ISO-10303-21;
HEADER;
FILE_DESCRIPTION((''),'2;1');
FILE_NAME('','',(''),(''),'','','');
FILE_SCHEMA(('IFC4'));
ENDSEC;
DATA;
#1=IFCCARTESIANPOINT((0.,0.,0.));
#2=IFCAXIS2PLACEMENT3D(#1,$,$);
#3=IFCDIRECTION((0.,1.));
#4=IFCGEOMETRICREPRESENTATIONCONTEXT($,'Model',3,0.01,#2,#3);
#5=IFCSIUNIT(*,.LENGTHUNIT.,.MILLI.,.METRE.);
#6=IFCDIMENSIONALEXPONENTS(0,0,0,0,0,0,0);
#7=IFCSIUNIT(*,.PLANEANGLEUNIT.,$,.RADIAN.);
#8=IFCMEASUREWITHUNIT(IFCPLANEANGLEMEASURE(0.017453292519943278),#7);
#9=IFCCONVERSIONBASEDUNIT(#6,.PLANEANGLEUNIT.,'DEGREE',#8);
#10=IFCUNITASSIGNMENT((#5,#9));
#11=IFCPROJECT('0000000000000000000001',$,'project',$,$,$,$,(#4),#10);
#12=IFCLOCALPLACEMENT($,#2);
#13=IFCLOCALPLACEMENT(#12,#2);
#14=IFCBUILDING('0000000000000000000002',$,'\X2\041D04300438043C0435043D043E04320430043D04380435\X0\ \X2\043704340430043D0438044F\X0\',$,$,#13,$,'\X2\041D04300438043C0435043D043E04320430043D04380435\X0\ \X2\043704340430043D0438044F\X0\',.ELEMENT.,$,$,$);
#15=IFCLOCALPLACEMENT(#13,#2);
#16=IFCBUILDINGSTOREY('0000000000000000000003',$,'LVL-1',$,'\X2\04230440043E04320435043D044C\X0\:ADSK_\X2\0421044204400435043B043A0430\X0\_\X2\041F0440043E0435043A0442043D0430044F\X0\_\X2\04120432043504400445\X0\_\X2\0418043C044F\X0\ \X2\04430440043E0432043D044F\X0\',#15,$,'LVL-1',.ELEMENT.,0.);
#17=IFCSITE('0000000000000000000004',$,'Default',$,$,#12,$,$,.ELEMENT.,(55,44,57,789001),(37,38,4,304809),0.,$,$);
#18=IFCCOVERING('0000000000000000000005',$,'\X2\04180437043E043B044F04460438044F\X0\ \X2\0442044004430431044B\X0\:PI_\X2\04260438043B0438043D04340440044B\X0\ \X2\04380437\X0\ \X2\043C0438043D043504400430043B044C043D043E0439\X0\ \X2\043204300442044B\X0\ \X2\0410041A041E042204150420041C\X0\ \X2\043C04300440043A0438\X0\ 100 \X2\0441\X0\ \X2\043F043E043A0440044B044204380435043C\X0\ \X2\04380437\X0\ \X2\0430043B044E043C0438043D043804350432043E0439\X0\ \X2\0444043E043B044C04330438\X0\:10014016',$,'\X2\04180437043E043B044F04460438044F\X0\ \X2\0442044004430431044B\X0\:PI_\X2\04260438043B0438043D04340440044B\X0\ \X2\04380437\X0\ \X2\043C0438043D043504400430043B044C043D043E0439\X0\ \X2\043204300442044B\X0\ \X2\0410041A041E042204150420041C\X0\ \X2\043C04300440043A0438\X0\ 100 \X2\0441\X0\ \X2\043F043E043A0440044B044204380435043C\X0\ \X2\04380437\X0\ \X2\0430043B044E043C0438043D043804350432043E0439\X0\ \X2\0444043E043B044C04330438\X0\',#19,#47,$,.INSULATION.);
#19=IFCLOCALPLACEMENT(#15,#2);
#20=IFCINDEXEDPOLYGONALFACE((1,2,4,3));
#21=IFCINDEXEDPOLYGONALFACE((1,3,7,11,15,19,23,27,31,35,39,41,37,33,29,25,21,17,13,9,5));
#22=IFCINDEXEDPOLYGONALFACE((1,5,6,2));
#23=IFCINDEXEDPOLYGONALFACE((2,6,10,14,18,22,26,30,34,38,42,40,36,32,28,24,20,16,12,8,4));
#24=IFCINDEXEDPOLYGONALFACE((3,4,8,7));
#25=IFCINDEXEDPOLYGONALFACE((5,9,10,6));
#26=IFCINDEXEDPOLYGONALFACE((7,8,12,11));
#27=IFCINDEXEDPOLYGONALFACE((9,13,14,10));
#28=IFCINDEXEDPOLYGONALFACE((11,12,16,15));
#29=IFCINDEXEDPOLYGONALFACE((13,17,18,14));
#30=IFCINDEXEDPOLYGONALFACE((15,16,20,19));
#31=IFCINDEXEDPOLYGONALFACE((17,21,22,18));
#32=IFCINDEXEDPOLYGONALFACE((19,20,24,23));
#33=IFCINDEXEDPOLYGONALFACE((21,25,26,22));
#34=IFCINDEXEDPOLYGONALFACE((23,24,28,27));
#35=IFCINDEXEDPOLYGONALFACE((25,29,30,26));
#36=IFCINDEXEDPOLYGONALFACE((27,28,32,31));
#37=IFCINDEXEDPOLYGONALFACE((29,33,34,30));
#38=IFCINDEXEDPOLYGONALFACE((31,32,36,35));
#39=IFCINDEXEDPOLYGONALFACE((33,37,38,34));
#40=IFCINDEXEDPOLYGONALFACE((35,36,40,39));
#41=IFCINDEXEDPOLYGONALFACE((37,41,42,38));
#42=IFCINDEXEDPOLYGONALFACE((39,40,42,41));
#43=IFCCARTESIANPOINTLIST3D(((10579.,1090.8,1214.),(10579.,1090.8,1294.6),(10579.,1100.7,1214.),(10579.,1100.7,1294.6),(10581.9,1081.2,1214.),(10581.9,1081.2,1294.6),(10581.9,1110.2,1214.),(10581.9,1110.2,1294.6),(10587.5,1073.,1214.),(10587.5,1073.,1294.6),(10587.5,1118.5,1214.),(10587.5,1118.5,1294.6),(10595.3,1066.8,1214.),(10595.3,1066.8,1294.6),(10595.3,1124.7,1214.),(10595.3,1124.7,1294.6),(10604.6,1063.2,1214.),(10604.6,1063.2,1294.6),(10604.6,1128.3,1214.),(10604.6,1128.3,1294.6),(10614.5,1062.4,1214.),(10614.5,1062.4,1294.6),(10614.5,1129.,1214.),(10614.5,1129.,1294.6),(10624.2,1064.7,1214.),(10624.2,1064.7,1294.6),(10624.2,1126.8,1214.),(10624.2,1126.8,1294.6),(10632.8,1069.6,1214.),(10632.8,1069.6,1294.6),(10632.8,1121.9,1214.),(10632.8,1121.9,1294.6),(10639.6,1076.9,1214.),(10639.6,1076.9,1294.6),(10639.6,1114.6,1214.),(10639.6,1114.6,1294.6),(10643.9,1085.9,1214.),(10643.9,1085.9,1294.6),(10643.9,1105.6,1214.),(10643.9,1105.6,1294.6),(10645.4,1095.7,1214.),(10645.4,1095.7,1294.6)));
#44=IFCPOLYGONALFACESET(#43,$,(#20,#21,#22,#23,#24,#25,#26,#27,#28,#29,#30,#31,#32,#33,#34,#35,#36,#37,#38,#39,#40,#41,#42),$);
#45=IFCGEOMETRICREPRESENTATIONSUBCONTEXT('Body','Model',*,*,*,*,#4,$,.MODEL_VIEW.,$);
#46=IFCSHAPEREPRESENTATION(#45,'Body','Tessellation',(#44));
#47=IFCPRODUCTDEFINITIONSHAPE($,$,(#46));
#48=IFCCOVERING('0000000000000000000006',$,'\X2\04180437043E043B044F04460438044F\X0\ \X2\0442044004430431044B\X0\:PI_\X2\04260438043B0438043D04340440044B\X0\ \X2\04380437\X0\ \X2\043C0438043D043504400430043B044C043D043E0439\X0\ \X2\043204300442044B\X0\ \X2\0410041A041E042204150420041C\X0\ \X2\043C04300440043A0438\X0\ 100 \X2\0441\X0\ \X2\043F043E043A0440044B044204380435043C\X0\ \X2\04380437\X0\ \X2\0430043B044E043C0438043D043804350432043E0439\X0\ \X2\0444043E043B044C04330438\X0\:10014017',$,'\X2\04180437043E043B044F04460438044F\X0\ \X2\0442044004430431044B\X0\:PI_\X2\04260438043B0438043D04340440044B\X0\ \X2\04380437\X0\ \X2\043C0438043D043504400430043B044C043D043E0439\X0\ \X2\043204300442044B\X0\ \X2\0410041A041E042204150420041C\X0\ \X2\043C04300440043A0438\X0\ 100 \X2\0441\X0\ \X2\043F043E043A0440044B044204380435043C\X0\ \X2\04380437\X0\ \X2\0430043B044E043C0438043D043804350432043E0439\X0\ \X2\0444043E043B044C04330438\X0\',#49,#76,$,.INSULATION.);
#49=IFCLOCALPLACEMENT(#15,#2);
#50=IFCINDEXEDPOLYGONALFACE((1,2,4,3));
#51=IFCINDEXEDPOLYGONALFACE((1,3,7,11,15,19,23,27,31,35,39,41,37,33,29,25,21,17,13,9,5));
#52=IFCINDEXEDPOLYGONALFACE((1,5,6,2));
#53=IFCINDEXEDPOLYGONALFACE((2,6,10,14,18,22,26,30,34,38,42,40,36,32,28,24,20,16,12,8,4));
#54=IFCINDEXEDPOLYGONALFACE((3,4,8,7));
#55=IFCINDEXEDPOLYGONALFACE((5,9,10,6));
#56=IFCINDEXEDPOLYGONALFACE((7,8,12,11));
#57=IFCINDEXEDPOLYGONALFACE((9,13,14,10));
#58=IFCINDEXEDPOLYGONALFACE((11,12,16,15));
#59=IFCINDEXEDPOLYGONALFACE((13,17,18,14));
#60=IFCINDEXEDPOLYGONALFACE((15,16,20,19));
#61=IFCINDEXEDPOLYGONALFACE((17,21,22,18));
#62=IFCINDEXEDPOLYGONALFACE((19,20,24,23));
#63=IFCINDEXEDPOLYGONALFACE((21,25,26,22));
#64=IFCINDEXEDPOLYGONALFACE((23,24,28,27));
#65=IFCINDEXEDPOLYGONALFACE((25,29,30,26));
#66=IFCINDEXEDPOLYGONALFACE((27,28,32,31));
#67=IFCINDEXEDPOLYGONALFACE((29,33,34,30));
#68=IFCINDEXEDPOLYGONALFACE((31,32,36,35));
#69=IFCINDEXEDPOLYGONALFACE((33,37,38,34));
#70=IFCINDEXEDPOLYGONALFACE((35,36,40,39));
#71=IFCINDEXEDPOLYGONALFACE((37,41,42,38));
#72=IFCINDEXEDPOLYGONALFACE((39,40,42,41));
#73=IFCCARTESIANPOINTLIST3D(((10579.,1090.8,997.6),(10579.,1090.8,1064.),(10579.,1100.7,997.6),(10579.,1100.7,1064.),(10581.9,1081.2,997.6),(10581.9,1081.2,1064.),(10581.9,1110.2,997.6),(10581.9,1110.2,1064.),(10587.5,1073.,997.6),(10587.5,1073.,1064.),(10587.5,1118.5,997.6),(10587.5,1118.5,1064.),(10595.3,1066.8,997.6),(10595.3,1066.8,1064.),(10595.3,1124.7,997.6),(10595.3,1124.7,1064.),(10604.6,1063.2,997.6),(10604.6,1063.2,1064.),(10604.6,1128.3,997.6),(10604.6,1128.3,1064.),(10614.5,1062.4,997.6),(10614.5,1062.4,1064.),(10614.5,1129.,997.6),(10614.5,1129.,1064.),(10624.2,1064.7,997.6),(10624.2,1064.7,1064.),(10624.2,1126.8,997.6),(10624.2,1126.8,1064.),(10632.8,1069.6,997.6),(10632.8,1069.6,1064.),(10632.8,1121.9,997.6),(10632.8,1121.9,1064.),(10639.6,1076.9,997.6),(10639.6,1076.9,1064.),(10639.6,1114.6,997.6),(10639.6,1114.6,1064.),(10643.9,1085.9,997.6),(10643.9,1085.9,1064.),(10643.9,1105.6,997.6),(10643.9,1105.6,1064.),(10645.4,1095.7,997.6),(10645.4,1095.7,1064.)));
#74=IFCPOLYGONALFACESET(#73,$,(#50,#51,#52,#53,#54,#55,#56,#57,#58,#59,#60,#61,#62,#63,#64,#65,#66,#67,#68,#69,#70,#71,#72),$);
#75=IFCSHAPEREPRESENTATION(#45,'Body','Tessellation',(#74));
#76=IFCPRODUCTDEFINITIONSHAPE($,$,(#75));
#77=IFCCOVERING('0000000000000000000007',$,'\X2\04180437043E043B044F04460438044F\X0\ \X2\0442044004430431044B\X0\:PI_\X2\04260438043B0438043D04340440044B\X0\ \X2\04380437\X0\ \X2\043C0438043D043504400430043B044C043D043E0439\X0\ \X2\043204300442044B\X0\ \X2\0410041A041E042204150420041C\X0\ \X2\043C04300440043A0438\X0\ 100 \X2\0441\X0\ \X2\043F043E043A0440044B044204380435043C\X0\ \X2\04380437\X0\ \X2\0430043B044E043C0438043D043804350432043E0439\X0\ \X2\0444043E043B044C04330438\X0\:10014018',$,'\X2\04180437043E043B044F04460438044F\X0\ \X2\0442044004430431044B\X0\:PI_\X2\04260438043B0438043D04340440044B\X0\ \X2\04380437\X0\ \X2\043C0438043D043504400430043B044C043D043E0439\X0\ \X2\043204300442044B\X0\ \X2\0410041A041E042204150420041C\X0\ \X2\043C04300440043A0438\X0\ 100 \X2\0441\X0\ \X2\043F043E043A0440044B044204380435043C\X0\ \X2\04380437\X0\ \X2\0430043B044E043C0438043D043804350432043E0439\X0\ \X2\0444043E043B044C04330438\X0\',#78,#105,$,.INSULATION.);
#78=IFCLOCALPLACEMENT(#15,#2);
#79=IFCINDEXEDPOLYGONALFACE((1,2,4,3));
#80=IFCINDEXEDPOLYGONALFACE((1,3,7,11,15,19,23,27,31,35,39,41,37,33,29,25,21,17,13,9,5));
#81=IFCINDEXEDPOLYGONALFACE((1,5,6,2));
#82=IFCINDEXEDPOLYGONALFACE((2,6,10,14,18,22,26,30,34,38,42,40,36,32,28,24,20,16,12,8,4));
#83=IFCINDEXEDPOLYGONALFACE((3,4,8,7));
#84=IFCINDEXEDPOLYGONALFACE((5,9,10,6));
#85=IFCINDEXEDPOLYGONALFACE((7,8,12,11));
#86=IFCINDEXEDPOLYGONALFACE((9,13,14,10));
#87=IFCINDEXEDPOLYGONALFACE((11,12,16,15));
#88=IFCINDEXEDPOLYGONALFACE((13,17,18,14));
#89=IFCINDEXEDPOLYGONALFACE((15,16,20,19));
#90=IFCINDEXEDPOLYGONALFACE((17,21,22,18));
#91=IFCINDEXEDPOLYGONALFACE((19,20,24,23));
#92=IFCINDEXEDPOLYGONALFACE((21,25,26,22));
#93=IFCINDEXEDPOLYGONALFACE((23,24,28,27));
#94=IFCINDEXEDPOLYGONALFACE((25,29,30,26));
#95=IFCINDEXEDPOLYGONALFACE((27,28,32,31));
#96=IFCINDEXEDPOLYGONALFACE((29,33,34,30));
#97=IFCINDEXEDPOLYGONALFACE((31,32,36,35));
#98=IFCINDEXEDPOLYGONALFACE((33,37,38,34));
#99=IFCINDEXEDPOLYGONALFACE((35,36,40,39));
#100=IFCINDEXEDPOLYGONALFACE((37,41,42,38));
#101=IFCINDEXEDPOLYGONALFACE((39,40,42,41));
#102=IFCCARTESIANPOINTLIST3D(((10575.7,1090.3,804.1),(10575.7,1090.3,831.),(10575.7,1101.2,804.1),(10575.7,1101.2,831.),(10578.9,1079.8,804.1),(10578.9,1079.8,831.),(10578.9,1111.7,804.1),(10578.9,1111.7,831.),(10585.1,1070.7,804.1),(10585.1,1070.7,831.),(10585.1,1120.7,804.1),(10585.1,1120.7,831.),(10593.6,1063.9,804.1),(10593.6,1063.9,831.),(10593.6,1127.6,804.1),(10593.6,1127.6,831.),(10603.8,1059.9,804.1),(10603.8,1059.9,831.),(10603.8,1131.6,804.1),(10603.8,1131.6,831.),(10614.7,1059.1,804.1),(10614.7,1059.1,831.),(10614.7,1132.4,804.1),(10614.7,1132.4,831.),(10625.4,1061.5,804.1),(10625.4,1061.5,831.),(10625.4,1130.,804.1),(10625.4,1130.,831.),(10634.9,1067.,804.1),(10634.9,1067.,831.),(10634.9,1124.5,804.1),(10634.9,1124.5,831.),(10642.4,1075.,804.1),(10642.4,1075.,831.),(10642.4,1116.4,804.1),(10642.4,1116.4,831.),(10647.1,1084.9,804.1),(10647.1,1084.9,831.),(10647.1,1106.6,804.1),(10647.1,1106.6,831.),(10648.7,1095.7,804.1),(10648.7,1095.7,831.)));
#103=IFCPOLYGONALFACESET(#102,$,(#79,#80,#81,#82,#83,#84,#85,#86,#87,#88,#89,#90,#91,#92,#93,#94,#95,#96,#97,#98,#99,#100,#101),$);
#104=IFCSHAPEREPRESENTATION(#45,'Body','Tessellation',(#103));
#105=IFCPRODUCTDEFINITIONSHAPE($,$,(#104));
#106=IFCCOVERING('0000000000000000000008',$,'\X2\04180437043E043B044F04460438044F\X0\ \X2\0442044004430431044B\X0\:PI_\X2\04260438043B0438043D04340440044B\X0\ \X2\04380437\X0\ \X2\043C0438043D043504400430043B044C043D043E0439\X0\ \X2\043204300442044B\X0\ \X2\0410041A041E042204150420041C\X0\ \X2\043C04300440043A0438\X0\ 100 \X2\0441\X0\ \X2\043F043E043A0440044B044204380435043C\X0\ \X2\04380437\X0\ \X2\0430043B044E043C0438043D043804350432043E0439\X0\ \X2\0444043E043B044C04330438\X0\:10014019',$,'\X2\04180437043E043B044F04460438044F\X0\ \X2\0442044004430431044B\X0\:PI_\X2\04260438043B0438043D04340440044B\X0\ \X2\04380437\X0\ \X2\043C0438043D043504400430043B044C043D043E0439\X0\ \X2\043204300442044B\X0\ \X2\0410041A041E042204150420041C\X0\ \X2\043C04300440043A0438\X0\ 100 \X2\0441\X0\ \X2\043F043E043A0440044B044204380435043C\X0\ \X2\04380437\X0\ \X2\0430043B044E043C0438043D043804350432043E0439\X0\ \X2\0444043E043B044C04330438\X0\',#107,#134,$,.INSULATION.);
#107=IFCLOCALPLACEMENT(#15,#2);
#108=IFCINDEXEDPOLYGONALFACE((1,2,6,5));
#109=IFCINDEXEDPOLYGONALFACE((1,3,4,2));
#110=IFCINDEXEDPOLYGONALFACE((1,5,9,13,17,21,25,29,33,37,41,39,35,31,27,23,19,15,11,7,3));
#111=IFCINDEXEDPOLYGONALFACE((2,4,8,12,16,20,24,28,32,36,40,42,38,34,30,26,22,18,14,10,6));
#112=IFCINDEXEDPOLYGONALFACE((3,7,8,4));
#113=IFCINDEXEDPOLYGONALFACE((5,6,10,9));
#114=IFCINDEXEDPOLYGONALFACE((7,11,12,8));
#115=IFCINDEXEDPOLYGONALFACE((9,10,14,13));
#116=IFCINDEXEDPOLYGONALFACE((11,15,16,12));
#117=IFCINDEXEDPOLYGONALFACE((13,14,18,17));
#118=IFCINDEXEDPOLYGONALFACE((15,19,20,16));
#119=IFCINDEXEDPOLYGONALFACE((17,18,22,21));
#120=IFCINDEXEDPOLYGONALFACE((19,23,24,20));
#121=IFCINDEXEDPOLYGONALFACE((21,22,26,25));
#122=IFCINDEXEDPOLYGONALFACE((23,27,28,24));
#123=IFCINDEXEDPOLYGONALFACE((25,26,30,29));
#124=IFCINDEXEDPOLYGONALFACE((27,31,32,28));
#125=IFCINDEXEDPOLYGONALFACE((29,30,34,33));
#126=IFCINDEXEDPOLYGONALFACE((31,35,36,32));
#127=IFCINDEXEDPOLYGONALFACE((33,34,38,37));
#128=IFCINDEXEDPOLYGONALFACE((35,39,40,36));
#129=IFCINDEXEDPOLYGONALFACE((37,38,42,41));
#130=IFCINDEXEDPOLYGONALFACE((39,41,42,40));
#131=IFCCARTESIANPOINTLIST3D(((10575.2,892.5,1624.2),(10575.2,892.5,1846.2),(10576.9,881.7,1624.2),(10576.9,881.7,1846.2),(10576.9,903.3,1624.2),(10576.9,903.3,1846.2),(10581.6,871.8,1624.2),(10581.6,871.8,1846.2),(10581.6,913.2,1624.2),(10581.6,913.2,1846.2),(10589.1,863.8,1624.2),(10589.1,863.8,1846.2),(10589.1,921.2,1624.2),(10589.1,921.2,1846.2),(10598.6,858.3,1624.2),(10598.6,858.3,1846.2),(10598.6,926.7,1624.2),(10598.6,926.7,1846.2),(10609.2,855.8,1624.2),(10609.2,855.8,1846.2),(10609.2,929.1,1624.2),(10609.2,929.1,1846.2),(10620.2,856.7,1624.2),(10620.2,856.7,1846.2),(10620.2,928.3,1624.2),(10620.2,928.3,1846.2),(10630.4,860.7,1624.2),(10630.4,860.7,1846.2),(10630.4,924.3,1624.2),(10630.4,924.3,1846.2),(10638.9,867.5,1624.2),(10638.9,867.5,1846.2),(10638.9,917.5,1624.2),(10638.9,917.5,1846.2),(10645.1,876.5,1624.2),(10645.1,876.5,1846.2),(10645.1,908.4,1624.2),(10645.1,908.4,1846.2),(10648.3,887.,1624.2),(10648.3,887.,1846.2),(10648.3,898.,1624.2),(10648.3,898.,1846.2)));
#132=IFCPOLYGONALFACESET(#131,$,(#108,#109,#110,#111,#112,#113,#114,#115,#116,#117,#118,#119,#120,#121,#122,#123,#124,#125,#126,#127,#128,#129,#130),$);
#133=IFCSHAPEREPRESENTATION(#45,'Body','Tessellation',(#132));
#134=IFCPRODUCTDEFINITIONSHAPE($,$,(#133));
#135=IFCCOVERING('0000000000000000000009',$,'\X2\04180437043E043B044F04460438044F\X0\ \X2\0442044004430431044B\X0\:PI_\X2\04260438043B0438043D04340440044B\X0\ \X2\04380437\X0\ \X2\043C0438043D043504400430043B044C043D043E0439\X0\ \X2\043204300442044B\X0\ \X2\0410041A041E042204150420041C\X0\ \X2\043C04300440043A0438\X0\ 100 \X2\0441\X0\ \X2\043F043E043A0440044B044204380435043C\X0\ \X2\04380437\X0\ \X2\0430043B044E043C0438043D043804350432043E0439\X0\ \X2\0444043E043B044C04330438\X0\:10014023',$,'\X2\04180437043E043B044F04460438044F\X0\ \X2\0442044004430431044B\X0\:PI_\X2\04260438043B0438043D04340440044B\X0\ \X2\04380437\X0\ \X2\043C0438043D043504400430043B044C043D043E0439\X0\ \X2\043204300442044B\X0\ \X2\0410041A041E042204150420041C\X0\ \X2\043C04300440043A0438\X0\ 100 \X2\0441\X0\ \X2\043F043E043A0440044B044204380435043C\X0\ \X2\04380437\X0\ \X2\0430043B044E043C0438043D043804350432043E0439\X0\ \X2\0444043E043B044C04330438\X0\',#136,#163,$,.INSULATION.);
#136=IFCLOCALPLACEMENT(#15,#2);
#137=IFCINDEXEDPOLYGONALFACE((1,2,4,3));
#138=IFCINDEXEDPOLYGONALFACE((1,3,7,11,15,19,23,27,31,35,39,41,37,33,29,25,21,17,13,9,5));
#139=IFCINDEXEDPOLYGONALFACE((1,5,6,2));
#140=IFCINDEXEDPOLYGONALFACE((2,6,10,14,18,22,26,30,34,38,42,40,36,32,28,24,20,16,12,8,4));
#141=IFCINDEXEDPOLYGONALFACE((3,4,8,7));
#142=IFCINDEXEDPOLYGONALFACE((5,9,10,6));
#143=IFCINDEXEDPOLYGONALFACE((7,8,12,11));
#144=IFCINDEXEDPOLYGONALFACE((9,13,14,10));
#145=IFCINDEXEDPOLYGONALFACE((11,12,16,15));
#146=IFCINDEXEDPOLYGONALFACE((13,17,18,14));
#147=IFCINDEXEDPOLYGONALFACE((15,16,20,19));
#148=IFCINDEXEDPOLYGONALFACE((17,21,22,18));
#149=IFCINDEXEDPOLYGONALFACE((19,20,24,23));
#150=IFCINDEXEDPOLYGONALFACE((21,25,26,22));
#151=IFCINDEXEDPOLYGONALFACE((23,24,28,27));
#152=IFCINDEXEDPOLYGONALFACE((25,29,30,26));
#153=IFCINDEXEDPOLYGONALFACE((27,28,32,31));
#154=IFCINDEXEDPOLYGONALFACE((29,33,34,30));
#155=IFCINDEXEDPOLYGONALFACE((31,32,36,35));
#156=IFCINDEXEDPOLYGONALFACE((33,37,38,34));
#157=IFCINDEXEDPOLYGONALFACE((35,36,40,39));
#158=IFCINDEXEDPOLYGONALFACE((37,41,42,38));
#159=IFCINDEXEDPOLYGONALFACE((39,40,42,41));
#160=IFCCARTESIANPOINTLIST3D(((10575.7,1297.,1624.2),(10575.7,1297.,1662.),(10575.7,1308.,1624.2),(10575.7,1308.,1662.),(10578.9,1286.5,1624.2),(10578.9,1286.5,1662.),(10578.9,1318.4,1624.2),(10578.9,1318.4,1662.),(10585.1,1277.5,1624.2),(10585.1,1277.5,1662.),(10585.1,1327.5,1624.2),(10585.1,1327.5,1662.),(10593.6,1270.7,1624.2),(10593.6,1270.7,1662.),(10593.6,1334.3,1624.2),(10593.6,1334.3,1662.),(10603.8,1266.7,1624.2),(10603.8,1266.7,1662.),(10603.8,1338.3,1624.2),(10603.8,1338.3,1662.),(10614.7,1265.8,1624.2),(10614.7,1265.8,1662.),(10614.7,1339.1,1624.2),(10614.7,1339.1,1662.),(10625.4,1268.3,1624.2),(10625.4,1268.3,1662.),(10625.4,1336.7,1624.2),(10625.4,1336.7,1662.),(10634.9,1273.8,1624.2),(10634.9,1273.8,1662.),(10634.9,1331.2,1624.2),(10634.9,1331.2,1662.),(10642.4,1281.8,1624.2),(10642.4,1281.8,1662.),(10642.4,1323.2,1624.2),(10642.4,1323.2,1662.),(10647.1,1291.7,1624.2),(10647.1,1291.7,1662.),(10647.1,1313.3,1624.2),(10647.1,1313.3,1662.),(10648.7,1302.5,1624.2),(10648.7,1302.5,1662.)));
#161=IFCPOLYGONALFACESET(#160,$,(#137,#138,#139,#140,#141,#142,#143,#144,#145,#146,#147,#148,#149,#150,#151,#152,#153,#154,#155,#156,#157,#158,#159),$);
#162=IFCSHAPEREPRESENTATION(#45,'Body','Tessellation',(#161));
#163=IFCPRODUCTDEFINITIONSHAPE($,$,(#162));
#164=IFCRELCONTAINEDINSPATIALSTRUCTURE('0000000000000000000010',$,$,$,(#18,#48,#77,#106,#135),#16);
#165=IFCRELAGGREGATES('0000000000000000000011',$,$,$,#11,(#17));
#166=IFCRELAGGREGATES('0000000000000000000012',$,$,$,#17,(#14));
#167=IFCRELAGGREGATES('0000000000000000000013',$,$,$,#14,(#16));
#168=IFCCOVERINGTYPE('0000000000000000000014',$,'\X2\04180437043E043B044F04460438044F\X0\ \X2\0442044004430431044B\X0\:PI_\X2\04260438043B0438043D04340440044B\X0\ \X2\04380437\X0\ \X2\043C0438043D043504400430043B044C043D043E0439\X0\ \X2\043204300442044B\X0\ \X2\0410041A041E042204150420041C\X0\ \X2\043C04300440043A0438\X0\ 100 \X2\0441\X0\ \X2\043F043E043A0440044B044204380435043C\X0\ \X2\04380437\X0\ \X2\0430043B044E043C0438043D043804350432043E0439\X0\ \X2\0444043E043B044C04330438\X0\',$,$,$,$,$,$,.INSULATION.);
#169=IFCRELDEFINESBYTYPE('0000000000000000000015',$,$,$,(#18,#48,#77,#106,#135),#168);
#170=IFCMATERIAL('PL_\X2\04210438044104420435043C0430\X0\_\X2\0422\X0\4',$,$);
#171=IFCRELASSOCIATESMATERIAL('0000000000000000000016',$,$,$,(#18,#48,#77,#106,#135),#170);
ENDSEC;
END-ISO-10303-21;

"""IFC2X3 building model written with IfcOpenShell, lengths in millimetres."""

from ifc_helpers import new_model, entity, si_unit, converted_unit, direction, frame, origin, origin_2d_with_axis, place, context, subcontext, project, spatial, circle, extrude, material, type_object, element, save


model = new_model("IFC2X3")

# Units and contexts
model_context = context("Model", 3, precision=0.01, world=origin(), true_north=direction((0.0, 1.0)))
body_context = subcontext(model_context, "Body", "Model", "MODEL_VIEW")
ifc_project = project(units=[si_unit("LENGTHUNIT", "METRE", prefix="MILLI"), converted_unit("PLANEANGLEUNIT", "DEGREE", entity("IfcPlaneAngleMeasure", 0.017453292519943278), si_unit("PLANEANGLEUNIT", "RADIAN"), dimensions=[0, 0, 0, 0, 0, 0, 0])], contexts=[model_context])

# Site, building, storey
site_placement = place(None, origin())
site = spatial("IfcSite", under=ifc_project, at=site_placement, Name="Default", CompositionType="ELEMENT", RefLatitude=(55, 44, 57, 789001), RefLongitude=(37, 38, 4, 304809), RefElevation=0.0)
building_placement = place(site_placement, origin())
building = spatial("IfcBuilding", under=site, at=building_placement, Name="Наименование здания", LongName="Наименование здания", CompositionType="ELEMENT")
storey_placement = place(building_placement, origin())
storey = spatial("IfcBuildingStorey", under=building, at=storey_placement, Name="LVL-1", ObjectType="Уровень:ADSK_Стрелка_Проектная_Вверх_Имя уровня", LongName="LVL-1", CompositionType="ELEMENT", Elevation=0.0)

# Coverings
covering_type = type_object("IfcCoveringType", Name="Изоляция трубы:PI_Цилиндры из минеральной ваты АКОТЕРМ марки 100 с покрытием из алюминиевой фольги", PredefinedType="INSULATION")
ifc_material_1 = material(Name="PL_Система_Т4")
covering_1_placement = place(storey_placement, origin())
element("IfcCovering", 1, at=covering_1_placement, inside=storey, type_object=covering_type, material=ifc_material_1, Name="Изоляция трубы:PI_Цилиндры из минеральной ваты АКОТЕРМ марки 100 с покрытием из алюминиевой фольги:10014016", ObjectType="Изоляция трубы:PI_Цилиндры из минеральной ваты АКОТЕРМ марки 100 с покрытием из алюминиевой фольги", PredefinedType="INSULATION", context=body_context, shape_type="SweptSolid", body=[
    extrude(circle(Radius=33.4, at=origin_2d_with_axis()), frame((10612.0, 1095.7, 1214.0)), (0.0, 0.0, 1.0), 80.6),
])
covering_2_placement = place(storey_placement, origin())
element("IfcCovering", 2, at=covering_2_placement, inside=storey, type_object=covering_type, material=ifc_material_1, Name="Изоляция трубы:PI_Цилиндры из минеральной ваты АКОТЕРМ марки 100 с покрытием из алюминиевой фольги:10014017", ObjectType="Изоляция трубы:PI_Цилиндры из минеральной ваты АКОТЕРМ марки 100 с покрытием из алюминиевой фольги", PredefinedType="INSULATION", context=body_context, shape_type="SweptSolid", body=[
    extrude(circle(Radius=33.4, at=origin_2d_with_axis()), frame((10612.0, 1095.7, 997.6)), (0.0, 0.0, 1.0), 66.4),
])
covering_3_placement = place(storey_placement, origin())
element("IfcCovering", 3, at=covering_3_placement, inside=storey, type_object=covering_type, material=ifc_material_1, Name="Изоляция трубы:PI_Цилиндры из минеральной ваты АКОТЕРМ марки 100 с покрытием из алюминиевой фольги:10014018", ObjectType="Изоляция трубы:PI_Цилиндры из минеральной ваты АКОТЕРМ марки 100 с покрытием из алюминиевой фольги", PredefinedType="INSULATION", context=body_context, shape_type="SweptSolid", body=[
    extrude(circle(Radius=36.8, at=origin_2d_with_axis()), frame((10612.0, 1095.7, 804.1)), (0.0, 0.0, 1.0), 26.9),
])
covering_4_placement = place(storey_placement, origin())
element("IfcCovering", 4, at=covering_4_placement, inside=storey, type_object=covering_type, material=ifc_material_1, Name="Изоляция трубы:PI_Цилиндры из минеральной ваты АКОТЕРМ марки 100 с покрытием из алюминиевой фольги:10014019", ObjectType="Изоляция трубы:PI_Цилиндры из минеральной ваты АКОТЕРМ марки 100 с покрытием из алюминиевой фольги", PredefinedType="INSULATION", context=body_context, shape_type="SweptSolid", body=[
    extrude(circle(Radius=36.8, at=origin_2d_with_axis()), frame((10612.0, 892.5, 1624.2), z_axis=(0.0, 0.0, 1.0), x_axis=(-1.0, 0.0, 0.0)), (0.0, 0.0, 1.0), 222.0),
])
covering_5_placement = place(storey_placement, origin())
element("IfcCovering", 5, at=covering_5_placement, inside=storey, type_object=covering_type, material=ifc_material_1, Name="Изоляция трубы:PI_Цилиндры из минеральной ваты АКОТЕРМ марки 100 с покрытием из алюминиевой фольги:10014023", ObjectType="Изоляция трубы:PI_Цилиндры из минеральной ваты АКОТЕРМ марки 100 с покрытием из алюминиевой фольги", PredefinedType="INSULATION", context=body_context, shape_type="SweptSolid", body=[
    extrude(circle(Radius=36.8, at=origin_2d_with_axis()), frame((10612.0, 1302.5, 1624.2)), (0.0, 0.0, 1.0), 37.8),
])

save(model, "model.ifc")
